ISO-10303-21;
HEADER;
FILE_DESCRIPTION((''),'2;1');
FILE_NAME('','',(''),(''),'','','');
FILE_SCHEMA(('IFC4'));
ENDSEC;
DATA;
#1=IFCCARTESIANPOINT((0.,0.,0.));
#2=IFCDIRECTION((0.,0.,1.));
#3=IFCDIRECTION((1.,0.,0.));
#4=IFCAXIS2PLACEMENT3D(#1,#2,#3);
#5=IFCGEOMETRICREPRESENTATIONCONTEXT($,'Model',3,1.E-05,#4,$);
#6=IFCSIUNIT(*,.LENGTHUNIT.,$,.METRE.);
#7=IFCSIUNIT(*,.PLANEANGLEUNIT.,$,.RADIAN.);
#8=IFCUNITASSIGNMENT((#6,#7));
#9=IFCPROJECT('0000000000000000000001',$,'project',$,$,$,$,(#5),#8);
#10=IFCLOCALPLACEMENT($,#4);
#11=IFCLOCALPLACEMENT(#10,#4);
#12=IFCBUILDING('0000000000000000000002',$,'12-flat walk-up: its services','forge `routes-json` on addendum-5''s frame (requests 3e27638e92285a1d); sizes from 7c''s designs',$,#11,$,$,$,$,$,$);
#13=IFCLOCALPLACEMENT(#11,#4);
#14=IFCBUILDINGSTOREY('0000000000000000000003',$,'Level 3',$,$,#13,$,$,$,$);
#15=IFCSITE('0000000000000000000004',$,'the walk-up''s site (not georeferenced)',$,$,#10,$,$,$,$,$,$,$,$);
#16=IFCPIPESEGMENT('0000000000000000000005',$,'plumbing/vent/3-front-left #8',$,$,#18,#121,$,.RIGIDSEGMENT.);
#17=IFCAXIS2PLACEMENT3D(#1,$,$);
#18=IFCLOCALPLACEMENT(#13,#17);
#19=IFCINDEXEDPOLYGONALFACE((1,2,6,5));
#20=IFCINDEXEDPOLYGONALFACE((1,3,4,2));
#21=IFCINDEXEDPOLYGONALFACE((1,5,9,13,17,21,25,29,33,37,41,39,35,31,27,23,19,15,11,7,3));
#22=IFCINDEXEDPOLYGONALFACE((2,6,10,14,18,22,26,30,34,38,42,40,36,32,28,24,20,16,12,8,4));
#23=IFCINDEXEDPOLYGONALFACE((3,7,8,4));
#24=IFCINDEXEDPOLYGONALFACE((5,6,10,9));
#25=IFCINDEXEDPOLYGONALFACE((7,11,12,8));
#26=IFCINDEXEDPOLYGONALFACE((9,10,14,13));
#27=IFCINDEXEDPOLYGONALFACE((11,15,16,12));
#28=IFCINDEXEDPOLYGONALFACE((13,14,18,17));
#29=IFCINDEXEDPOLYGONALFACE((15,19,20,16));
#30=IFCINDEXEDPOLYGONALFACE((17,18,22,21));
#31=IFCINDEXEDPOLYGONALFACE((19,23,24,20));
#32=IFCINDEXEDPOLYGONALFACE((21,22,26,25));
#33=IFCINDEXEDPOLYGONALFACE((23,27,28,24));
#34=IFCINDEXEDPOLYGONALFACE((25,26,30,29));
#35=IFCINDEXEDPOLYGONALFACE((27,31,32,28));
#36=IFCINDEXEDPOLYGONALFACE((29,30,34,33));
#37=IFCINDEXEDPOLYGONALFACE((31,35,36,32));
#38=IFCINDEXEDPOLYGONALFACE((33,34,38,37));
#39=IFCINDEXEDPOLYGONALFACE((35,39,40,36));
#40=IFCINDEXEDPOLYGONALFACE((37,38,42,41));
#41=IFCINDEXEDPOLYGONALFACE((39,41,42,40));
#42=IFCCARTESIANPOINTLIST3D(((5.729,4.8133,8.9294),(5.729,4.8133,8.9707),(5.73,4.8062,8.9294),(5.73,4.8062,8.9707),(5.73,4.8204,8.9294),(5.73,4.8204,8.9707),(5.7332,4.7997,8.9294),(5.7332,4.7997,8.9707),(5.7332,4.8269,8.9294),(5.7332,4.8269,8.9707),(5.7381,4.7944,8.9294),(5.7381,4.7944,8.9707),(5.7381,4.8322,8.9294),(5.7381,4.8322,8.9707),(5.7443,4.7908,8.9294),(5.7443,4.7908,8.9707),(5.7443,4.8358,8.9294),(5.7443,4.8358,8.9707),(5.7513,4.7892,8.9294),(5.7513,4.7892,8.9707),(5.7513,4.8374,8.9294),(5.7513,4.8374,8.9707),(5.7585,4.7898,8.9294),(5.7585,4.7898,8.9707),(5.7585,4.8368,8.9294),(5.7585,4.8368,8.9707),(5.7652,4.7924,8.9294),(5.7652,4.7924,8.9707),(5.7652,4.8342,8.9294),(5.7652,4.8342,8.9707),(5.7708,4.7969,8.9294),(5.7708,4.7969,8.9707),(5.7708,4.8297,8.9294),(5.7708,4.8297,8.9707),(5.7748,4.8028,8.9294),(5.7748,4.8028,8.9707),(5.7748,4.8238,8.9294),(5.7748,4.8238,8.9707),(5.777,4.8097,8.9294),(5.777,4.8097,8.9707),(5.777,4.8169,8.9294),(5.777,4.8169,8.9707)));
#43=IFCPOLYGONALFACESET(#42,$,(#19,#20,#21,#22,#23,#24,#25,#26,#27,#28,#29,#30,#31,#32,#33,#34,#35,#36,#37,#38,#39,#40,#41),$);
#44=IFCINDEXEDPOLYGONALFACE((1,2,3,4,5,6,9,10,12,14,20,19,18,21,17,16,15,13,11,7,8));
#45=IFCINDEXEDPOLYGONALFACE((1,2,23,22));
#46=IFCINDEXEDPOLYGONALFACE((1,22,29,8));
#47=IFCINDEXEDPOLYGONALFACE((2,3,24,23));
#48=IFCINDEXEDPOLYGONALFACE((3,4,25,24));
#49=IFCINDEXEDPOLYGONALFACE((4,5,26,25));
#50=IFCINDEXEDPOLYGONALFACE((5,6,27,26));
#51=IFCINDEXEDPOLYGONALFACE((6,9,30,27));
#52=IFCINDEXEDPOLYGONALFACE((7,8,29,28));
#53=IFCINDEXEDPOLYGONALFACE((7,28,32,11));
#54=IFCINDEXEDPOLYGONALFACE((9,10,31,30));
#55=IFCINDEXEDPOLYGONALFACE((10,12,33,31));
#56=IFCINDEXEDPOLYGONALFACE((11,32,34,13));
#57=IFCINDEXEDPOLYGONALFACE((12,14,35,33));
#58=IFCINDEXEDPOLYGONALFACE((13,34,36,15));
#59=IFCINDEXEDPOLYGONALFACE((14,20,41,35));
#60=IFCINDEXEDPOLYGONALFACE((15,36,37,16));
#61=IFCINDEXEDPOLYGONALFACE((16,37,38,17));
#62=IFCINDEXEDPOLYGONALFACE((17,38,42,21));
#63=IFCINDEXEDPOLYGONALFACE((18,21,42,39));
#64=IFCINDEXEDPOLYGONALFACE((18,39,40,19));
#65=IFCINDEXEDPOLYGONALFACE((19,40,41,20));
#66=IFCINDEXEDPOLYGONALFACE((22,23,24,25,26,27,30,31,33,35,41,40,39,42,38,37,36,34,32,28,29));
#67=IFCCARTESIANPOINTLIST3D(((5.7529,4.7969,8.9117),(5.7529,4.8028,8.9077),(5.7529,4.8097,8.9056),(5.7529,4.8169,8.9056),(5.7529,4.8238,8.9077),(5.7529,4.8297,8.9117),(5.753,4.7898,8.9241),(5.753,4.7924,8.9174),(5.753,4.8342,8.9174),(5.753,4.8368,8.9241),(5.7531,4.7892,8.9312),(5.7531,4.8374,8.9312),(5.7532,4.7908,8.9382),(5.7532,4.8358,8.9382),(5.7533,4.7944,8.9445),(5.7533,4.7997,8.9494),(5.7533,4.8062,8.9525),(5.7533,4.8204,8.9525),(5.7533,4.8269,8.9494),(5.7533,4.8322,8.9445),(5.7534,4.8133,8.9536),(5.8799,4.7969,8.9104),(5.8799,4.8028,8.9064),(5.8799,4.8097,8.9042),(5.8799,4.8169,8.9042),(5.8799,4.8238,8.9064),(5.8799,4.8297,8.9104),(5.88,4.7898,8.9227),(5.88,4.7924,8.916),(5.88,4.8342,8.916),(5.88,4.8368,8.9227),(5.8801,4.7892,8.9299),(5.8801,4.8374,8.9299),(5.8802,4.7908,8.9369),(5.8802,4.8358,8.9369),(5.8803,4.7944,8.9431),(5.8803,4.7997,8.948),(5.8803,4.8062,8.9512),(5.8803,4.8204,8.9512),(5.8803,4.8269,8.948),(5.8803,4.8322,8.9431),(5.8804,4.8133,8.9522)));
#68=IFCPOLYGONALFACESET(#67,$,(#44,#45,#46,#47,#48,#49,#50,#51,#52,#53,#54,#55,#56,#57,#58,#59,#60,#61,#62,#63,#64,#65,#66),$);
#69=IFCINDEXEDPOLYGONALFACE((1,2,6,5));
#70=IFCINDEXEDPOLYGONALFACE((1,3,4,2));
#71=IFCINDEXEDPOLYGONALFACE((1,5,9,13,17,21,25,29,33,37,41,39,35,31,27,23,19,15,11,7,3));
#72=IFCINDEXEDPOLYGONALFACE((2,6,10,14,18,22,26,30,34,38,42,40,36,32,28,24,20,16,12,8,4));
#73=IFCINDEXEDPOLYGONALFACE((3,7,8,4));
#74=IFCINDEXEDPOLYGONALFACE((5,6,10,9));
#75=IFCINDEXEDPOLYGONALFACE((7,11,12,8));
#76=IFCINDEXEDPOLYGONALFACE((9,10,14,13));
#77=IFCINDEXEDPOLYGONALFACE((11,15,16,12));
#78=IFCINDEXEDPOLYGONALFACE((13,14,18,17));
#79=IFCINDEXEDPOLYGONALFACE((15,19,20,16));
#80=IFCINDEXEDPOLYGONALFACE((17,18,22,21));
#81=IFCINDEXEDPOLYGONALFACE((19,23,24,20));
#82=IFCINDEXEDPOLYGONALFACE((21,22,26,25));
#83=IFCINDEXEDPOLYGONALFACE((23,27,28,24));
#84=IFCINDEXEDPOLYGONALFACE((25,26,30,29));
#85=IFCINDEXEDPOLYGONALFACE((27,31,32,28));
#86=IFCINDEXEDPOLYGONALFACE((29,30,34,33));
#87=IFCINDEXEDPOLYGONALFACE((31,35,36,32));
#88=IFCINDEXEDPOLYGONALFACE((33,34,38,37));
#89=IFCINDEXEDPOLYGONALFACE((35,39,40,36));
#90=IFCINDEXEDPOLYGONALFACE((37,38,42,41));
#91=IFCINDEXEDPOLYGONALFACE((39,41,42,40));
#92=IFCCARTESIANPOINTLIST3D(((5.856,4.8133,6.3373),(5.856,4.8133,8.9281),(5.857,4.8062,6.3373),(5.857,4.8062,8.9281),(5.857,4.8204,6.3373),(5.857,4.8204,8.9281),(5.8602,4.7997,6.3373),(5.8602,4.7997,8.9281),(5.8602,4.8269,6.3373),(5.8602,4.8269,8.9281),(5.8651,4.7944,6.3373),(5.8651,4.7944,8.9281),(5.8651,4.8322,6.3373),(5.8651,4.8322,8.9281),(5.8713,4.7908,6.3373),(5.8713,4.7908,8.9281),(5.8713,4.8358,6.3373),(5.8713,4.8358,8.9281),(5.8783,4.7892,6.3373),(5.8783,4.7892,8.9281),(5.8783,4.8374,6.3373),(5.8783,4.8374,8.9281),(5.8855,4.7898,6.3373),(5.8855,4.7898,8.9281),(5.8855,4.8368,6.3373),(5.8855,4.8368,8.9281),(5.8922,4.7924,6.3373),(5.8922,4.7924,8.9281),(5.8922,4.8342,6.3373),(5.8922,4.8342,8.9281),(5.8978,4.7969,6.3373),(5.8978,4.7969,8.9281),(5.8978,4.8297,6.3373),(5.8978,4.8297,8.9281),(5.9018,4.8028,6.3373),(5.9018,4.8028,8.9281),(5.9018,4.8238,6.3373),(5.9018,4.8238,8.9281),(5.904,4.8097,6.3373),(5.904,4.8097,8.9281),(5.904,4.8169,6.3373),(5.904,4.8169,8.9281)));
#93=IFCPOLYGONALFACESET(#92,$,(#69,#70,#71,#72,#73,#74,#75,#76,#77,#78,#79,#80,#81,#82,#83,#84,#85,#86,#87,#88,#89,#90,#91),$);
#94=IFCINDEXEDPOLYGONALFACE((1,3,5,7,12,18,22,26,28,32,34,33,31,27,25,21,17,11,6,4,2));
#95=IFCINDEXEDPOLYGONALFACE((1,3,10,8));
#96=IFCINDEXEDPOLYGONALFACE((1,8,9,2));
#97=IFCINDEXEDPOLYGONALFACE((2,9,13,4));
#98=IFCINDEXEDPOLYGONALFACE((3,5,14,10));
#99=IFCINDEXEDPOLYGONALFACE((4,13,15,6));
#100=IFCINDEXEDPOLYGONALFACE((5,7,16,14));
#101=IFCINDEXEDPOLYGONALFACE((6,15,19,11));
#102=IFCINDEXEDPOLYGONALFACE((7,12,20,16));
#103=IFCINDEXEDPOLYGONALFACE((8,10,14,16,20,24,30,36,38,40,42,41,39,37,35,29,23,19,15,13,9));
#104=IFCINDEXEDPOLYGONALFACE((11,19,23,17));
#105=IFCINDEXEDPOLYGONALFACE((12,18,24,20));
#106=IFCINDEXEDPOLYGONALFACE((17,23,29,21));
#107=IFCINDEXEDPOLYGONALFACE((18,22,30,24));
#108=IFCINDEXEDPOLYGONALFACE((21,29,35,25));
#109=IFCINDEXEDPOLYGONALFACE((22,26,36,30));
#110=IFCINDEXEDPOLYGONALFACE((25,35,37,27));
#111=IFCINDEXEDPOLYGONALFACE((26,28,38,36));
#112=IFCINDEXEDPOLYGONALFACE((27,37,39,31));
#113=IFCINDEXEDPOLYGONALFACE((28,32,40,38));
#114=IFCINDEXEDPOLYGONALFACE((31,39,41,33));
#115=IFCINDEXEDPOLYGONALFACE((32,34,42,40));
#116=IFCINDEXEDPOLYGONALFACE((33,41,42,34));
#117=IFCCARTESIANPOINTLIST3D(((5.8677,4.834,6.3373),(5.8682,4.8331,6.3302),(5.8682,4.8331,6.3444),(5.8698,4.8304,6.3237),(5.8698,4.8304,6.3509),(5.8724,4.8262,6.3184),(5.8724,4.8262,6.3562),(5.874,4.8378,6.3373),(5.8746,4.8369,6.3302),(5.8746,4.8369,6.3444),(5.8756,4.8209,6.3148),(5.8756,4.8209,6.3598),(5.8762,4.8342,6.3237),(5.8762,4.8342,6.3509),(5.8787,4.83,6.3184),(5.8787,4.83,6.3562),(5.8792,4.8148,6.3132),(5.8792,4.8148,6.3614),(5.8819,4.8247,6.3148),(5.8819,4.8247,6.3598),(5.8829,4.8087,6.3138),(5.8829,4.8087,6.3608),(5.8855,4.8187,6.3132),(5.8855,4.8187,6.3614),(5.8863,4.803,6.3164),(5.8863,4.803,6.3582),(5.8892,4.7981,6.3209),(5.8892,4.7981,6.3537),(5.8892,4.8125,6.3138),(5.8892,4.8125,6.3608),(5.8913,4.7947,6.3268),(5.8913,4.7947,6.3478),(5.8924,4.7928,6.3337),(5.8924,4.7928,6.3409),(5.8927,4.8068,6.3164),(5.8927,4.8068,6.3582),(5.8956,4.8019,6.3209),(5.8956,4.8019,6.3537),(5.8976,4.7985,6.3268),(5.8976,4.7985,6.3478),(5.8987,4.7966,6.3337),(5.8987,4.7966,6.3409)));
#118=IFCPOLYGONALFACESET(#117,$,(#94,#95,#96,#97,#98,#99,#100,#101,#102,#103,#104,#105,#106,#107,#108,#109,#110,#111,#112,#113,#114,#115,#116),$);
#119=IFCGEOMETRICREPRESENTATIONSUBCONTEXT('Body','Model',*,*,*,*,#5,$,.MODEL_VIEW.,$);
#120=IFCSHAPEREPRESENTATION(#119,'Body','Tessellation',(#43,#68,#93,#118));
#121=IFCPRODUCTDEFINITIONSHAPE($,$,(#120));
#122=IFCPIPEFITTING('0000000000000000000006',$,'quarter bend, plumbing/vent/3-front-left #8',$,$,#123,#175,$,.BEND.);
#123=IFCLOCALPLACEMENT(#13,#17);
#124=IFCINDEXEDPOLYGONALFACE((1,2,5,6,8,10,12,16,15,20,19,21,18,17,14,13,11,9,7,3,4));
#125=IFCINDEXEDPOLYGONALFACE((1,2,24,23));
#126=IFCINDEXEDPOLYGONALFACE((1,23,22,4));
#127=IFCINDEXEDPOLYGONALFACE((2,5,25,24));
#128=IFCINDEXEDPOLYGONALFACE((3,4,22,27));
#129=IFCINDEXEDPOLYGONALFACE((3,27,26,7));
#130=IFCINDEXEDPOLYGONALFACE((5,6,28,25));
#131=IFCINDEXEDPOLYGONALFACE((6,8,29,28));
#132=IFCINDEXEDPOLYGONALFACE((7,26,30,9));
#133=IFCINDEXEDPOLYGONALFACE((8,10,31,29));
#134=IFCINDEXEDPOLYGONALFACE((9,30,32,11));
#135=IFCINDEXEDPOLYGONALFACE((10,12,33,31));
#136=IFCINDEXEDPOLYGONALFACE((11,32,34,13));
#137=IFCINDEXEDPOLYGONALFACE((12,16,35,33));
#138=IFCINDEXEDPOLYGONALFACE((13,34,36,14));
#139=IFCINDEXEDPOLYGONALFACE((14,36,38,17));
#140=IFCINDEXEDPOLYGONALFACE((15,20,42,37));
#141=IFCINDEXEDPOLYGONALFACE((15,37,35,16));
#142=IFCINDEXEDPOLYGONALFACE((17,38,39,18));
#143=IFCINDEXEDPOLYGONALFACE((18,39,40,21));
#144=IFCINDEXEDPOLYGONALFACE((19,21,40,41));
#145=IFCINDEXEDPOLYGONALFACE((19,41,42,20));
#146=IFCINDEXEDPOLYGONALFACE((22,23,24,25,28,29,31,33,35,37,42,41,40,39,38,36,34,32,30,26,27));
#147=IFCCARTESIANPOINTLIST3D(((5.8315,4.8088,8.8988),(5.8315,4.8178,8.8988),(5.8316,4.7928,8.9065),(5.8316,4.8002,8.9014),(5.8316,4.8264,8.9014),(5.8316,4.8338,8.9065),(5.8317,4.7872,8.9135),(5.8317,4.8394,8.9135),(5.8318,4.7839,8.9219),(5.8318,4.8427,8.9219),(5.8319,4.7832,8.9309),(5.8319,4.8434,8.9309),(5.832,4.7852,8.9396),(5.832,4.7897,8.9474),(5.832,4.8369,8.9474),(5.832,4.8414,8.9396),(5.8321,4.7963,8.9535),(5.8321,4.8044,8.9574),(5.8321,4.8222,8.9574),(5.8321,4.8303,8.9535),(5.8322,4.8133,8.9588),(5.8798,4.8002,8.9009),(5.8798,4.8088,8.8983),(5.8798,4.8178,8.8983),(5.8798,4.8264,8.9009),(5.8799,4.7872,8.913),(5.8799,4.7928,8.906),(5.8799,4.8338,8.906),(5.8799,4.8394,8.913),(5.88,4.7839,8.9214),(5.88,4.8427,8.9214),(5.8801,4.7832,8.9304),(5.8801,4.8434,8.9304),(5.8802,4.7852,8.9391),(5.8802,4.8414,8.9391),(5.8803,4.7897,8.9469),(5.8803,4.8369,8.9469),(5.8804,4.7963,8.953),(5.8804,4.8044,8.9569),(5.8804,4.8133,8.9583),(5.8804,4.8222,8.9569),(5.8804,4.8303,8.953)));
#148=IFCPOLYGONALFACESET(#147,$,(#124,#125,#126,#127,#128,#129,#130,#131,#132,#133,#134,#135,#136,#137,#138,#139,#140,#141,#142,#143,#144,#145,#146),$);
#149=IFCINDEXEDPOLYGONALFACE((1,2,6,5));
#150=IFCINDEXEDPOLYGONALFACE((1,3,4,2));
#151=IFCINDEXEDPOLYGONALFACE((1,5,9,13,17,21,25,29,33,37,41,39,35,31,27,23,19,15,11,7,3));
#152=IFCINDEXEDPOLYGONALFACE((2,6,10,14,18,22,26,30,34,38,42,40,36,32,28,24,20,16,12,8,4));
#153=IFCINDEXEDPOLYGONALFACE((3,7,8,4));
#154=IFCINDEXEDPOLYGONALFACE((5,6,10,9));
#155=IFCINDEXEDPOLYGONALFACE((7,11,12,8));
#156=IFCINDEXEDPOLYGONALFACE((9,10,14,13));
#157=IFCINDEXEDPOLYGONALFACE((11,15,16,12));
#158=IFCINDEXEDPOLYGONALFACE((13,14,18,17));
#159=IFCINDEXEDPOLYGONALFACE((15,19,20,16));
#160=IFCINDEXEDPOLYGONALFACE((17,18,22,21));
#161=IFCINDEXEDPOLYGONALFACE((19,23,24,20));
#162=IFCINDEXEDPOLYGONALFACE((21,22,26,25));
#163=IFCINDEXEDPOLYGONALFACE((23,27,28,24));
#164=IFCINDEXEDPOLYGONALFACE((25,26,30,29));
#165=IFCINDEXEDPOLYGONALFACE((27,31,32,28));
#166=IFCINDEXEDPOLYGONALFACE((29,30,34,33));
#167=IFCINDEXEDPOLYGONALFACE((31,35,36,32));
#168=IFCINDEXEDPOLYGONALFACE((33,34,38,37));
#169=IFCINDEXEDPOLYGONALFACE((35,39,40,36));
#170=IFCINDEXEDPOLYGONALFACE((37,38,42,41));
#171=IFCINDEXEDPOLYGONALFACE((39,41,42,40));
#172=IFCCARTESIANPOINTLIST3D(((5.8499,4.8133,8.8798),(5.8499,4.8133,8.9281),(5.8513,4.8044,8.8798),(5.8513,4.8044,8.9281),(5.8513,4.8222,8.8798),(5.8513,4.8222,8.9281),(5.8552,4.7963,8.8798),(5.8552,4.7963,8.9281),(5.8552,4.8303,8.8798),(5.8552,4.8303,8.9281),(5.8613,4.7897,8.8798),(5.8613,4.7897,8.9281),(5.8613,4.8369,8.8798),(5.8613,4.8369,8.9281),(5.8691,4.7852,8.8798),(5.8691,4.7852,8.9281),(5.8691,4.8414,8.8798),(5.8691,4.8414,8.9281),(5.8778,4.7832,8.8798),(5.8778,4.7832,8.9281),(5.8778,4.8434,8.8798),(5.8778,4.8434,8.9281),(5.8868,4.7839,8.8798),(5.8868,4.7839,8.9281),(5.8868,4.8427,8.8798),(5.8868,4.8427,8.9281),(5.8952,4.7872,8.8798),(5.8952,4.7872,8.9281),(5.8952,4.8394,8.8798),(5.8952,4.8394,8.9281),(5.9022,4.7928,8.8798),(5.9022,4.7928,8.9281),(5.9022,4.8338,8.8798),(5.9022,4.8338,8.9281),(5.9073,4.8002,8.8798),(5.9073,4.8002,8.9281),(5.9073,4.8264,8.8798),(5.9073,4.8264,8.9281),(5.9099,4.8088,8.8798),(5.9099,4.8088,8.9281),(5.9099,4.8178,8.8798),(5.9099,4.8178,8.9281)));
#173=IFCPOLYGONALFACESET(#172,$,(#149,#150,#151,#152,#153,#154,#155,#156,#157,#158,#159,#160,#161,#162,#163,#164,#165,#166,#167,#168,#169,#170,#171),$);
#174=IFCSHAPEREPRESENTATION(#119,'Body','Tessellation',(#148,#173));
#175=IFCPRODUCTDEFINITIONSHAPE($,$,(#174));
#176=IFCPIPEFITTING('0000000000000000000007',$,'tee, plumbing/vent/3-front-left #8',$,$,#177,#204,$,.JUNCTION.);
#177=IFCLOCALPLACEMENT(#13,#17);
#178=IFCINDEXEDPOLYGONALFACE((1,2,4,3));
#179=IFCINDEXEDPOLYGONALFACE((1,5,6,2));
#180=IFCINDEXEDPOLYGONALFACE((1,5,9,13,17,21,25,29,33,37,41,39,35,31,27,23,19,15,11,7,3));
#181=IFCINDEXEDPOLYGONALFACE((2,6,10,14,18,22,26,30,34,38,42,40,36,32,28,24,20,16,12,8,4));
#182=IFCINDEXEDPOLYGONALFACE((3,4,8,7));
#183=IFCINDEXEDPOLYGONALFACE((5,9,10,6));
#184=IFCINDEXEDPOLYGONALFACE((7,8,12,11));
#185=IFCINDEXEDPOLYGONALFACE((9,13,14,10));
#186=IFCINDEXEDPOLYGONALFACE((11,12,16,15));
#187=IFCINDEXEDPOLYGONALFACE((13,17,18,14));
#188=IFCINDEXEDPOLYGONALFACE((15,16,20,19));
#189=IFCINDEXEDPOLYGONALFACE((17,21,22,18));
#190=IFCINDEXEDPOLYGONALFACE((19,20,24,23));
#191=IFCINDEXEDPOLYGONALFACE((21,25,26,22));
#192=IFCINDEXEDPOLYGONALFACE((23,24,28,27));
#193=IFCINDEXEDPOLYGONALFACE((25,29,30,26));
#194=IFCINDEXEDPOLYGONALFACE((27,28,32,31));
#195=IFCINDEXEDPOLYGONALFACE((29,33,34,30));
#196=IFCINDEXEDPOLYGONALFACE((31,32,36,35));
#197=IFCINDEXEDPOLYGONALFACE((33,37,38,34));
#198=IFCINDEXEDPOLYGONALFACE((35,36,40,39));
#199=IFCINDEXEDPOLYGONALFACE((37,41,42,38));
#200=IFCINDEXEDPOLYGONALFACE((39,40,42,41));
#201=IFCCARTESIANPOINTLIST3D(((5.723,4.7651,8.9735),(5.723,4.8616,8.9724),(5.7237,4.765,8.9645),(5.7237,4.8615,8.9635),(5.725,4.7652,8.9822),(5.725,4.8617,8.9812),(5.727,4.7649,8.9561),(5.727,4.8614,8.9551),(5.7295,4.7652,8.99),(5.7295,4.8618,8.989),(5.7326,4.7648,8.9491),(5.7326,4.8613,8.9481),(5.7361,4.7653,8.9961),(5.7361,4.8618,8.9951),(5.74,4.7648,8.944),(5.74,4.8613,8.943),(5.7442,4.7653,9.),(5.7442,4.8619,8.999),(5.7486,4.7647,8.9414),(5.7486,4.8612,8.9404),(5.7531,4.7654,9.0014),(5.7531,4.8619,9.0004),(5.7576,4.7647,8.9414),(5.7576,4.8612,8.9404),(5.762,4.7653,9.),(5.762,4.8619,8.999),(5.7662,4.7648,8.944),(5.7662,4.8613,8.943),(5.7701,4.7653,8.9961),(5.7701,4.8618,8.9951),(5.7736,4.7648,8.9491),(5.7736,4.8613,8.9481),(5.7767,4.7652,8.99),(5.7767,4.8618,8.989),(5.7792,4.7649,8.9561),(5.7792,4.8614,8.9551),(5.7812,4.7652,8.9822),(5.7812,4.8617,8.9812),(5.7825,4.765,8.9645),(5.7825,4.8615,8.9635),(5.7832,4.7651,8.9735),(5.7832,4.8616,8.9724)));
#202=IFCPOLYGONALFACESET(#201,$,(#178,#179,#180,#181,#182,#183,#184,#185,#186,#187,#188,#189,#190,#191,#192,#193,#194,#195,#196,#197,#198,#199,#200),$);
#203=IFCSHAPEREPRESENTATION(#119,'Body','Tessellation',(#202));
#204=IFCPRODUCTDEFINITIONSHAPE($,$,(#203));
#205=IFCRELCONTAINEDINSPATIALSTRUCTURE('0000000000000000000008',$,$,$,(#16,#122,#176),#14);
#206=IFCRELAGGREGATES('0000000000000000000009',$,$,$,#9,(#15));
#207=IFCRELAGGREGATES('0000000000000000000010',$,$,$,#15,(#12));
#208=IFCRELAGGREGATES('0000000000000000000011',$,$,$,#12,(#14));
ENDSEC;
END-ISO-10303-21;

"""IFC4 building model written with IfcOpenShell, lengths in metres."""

from ifc_helpers import new_model, entity, si_unit, frame, origin_with_axes, place, context, subcontext, project, spatial, element, save


model = new_model("IFC4")

# Units and contexts
model_context = context("Model", 3, precision=1e-05, world=origin_with_axes())
body_context = subcontext(model_context, "Body", "Model", "MODEL_VIEW")
ifc_project = project(units=[si_unit("LENGTHUNIT", "METRE"), si_unit("PLANEANGLEUNIT", "RADIAN")], contexts=[model_context])

# Site, building, storey
site_placement = place(None, origin_with_axes())
site = spatial("IfcSite", under=ifc_project, at=site_placement, Name="the walk-up's site (not georeferenced)")
building_placement = place(site_placement, origin_with_axes())
building = spatial("IfcBuilding", under=site, at=building_placement, Name="12-flat walk-up: its services", Description="forge `routes-json` on addendum-5's frame (requests 3e27638e92285a1d); sizes from 7c's designs")
storey_placement = place(building_placement, origin_with_axes())
storey = spatial("IfcBuildingStorey", under=building, at=storey_placement, Name="Level 3")

# Pipe segment
pipe_segment_1_placement = place(storey_placement, frame((5.7531, 4.8133, 8.9707), z_axis=(0.0, 0.0, 1.0), x_axis=(1.0, 0.0, 0.0)))
element("IfcPipeSegment", 1, at=pipe_segment_1_placement, inside=storey, Name="plumbing/vent/3-front-left #8", PredefinedType="RIGIDSEGMENT", context=body_context, shape_type="AdvancedSweptSolid", body=[
    entity("IfcSweptDiskSolid", entity("IfcPolyline", [entity("IfcCartesianPoint", [0.0, 0.0, 0.0]), entity("IfcCartesianPoint", [0.0, 0.0, -0.0413])]), 0.0241),
    entity("IfcSweptDiskSolid", entity("IfcPolyline", [entity("IfcCartesianPoint", [0.0, 0.0, -0.0413]), entity("IfcCartesianPoint", [0.127, 0.0, -0.0426])]), 0.0241),
    entity("IfcSweptDiskSolid", entity("IfcPolyline", [entity("IfcCartesianPoint", [0.127, 0.0, -0.0426]), entity("IfcCartesianPoint", [0.127, 0.0, -2.6334])]), 0.0241),
    entity("IfcSweptDiskSolid", entity("IfcPolyline", [entity("IfcCartesianPoint", [0.127, 0.0, -2.6334]), entity("IfcCartesianPoint", [0.1334, 0.0038, -2.6334])]), 0.0241),
])

# Pipe fittings
pipe_fitting_1_placement = place(storey_placement, frame((5.8318, 4.8133, 8.9286), z_axis=(0.0, 0.0, 1.0), x_axis=(1.0, 0.0, 0.0)))
element("IfcPipeFitting", 2, at=pipe_fitting_1_placement, inside=storey, Name="quarter bend, plumbing/vent/3-front-left #8", PredefinedType="BEND", context=body_context, shape_type="AdvancedSweptSolid", body=[
    entity("IfcSweptDiskSolid", entity("IfcPolyline", [entity("IfcCartesianPoint", [0.0, 0.0, 0.0]), entity("IfcCartesianPoint", [0.0483, 0.0, -0.0005])]), 0.0302),
    entity("IfcSweptDiskSolid", entity("IfcPolyline", [entity("IfcCartesianPoint", [0.0483, 0.0, -0.0005]), entity("IfcCartesianPoint", [0.0483, 0.0, -0.0488])]), 0.0302),
])
pipe_fitting_2_placement = place(storey_placement, frame((5.7531, 4.765, 8.9712), z_axis=(0.0, 0.0, 1.0), x_axis=(1.0, 0.0, 0.0)))
element("IfcPipeFitting", 3, at=pipe_fitting_2_placement, inside=storey, Name="tee, plumbing/vent/3-front-left #8", PredefinedType="JUNCTION", context=body_context, shape_type="AdvancedSweptSolid", body=[
    entity("IfcSweptDiskSolid", entity("IfcPolyline", [entity("IfcCartesianPoint", [0.0, 0.0, 0.0]), entity("IfcCartesianPoint", [0.0, 0.0965, -0.001])]), 0.0302),
])

save(model, "model.ifc")
